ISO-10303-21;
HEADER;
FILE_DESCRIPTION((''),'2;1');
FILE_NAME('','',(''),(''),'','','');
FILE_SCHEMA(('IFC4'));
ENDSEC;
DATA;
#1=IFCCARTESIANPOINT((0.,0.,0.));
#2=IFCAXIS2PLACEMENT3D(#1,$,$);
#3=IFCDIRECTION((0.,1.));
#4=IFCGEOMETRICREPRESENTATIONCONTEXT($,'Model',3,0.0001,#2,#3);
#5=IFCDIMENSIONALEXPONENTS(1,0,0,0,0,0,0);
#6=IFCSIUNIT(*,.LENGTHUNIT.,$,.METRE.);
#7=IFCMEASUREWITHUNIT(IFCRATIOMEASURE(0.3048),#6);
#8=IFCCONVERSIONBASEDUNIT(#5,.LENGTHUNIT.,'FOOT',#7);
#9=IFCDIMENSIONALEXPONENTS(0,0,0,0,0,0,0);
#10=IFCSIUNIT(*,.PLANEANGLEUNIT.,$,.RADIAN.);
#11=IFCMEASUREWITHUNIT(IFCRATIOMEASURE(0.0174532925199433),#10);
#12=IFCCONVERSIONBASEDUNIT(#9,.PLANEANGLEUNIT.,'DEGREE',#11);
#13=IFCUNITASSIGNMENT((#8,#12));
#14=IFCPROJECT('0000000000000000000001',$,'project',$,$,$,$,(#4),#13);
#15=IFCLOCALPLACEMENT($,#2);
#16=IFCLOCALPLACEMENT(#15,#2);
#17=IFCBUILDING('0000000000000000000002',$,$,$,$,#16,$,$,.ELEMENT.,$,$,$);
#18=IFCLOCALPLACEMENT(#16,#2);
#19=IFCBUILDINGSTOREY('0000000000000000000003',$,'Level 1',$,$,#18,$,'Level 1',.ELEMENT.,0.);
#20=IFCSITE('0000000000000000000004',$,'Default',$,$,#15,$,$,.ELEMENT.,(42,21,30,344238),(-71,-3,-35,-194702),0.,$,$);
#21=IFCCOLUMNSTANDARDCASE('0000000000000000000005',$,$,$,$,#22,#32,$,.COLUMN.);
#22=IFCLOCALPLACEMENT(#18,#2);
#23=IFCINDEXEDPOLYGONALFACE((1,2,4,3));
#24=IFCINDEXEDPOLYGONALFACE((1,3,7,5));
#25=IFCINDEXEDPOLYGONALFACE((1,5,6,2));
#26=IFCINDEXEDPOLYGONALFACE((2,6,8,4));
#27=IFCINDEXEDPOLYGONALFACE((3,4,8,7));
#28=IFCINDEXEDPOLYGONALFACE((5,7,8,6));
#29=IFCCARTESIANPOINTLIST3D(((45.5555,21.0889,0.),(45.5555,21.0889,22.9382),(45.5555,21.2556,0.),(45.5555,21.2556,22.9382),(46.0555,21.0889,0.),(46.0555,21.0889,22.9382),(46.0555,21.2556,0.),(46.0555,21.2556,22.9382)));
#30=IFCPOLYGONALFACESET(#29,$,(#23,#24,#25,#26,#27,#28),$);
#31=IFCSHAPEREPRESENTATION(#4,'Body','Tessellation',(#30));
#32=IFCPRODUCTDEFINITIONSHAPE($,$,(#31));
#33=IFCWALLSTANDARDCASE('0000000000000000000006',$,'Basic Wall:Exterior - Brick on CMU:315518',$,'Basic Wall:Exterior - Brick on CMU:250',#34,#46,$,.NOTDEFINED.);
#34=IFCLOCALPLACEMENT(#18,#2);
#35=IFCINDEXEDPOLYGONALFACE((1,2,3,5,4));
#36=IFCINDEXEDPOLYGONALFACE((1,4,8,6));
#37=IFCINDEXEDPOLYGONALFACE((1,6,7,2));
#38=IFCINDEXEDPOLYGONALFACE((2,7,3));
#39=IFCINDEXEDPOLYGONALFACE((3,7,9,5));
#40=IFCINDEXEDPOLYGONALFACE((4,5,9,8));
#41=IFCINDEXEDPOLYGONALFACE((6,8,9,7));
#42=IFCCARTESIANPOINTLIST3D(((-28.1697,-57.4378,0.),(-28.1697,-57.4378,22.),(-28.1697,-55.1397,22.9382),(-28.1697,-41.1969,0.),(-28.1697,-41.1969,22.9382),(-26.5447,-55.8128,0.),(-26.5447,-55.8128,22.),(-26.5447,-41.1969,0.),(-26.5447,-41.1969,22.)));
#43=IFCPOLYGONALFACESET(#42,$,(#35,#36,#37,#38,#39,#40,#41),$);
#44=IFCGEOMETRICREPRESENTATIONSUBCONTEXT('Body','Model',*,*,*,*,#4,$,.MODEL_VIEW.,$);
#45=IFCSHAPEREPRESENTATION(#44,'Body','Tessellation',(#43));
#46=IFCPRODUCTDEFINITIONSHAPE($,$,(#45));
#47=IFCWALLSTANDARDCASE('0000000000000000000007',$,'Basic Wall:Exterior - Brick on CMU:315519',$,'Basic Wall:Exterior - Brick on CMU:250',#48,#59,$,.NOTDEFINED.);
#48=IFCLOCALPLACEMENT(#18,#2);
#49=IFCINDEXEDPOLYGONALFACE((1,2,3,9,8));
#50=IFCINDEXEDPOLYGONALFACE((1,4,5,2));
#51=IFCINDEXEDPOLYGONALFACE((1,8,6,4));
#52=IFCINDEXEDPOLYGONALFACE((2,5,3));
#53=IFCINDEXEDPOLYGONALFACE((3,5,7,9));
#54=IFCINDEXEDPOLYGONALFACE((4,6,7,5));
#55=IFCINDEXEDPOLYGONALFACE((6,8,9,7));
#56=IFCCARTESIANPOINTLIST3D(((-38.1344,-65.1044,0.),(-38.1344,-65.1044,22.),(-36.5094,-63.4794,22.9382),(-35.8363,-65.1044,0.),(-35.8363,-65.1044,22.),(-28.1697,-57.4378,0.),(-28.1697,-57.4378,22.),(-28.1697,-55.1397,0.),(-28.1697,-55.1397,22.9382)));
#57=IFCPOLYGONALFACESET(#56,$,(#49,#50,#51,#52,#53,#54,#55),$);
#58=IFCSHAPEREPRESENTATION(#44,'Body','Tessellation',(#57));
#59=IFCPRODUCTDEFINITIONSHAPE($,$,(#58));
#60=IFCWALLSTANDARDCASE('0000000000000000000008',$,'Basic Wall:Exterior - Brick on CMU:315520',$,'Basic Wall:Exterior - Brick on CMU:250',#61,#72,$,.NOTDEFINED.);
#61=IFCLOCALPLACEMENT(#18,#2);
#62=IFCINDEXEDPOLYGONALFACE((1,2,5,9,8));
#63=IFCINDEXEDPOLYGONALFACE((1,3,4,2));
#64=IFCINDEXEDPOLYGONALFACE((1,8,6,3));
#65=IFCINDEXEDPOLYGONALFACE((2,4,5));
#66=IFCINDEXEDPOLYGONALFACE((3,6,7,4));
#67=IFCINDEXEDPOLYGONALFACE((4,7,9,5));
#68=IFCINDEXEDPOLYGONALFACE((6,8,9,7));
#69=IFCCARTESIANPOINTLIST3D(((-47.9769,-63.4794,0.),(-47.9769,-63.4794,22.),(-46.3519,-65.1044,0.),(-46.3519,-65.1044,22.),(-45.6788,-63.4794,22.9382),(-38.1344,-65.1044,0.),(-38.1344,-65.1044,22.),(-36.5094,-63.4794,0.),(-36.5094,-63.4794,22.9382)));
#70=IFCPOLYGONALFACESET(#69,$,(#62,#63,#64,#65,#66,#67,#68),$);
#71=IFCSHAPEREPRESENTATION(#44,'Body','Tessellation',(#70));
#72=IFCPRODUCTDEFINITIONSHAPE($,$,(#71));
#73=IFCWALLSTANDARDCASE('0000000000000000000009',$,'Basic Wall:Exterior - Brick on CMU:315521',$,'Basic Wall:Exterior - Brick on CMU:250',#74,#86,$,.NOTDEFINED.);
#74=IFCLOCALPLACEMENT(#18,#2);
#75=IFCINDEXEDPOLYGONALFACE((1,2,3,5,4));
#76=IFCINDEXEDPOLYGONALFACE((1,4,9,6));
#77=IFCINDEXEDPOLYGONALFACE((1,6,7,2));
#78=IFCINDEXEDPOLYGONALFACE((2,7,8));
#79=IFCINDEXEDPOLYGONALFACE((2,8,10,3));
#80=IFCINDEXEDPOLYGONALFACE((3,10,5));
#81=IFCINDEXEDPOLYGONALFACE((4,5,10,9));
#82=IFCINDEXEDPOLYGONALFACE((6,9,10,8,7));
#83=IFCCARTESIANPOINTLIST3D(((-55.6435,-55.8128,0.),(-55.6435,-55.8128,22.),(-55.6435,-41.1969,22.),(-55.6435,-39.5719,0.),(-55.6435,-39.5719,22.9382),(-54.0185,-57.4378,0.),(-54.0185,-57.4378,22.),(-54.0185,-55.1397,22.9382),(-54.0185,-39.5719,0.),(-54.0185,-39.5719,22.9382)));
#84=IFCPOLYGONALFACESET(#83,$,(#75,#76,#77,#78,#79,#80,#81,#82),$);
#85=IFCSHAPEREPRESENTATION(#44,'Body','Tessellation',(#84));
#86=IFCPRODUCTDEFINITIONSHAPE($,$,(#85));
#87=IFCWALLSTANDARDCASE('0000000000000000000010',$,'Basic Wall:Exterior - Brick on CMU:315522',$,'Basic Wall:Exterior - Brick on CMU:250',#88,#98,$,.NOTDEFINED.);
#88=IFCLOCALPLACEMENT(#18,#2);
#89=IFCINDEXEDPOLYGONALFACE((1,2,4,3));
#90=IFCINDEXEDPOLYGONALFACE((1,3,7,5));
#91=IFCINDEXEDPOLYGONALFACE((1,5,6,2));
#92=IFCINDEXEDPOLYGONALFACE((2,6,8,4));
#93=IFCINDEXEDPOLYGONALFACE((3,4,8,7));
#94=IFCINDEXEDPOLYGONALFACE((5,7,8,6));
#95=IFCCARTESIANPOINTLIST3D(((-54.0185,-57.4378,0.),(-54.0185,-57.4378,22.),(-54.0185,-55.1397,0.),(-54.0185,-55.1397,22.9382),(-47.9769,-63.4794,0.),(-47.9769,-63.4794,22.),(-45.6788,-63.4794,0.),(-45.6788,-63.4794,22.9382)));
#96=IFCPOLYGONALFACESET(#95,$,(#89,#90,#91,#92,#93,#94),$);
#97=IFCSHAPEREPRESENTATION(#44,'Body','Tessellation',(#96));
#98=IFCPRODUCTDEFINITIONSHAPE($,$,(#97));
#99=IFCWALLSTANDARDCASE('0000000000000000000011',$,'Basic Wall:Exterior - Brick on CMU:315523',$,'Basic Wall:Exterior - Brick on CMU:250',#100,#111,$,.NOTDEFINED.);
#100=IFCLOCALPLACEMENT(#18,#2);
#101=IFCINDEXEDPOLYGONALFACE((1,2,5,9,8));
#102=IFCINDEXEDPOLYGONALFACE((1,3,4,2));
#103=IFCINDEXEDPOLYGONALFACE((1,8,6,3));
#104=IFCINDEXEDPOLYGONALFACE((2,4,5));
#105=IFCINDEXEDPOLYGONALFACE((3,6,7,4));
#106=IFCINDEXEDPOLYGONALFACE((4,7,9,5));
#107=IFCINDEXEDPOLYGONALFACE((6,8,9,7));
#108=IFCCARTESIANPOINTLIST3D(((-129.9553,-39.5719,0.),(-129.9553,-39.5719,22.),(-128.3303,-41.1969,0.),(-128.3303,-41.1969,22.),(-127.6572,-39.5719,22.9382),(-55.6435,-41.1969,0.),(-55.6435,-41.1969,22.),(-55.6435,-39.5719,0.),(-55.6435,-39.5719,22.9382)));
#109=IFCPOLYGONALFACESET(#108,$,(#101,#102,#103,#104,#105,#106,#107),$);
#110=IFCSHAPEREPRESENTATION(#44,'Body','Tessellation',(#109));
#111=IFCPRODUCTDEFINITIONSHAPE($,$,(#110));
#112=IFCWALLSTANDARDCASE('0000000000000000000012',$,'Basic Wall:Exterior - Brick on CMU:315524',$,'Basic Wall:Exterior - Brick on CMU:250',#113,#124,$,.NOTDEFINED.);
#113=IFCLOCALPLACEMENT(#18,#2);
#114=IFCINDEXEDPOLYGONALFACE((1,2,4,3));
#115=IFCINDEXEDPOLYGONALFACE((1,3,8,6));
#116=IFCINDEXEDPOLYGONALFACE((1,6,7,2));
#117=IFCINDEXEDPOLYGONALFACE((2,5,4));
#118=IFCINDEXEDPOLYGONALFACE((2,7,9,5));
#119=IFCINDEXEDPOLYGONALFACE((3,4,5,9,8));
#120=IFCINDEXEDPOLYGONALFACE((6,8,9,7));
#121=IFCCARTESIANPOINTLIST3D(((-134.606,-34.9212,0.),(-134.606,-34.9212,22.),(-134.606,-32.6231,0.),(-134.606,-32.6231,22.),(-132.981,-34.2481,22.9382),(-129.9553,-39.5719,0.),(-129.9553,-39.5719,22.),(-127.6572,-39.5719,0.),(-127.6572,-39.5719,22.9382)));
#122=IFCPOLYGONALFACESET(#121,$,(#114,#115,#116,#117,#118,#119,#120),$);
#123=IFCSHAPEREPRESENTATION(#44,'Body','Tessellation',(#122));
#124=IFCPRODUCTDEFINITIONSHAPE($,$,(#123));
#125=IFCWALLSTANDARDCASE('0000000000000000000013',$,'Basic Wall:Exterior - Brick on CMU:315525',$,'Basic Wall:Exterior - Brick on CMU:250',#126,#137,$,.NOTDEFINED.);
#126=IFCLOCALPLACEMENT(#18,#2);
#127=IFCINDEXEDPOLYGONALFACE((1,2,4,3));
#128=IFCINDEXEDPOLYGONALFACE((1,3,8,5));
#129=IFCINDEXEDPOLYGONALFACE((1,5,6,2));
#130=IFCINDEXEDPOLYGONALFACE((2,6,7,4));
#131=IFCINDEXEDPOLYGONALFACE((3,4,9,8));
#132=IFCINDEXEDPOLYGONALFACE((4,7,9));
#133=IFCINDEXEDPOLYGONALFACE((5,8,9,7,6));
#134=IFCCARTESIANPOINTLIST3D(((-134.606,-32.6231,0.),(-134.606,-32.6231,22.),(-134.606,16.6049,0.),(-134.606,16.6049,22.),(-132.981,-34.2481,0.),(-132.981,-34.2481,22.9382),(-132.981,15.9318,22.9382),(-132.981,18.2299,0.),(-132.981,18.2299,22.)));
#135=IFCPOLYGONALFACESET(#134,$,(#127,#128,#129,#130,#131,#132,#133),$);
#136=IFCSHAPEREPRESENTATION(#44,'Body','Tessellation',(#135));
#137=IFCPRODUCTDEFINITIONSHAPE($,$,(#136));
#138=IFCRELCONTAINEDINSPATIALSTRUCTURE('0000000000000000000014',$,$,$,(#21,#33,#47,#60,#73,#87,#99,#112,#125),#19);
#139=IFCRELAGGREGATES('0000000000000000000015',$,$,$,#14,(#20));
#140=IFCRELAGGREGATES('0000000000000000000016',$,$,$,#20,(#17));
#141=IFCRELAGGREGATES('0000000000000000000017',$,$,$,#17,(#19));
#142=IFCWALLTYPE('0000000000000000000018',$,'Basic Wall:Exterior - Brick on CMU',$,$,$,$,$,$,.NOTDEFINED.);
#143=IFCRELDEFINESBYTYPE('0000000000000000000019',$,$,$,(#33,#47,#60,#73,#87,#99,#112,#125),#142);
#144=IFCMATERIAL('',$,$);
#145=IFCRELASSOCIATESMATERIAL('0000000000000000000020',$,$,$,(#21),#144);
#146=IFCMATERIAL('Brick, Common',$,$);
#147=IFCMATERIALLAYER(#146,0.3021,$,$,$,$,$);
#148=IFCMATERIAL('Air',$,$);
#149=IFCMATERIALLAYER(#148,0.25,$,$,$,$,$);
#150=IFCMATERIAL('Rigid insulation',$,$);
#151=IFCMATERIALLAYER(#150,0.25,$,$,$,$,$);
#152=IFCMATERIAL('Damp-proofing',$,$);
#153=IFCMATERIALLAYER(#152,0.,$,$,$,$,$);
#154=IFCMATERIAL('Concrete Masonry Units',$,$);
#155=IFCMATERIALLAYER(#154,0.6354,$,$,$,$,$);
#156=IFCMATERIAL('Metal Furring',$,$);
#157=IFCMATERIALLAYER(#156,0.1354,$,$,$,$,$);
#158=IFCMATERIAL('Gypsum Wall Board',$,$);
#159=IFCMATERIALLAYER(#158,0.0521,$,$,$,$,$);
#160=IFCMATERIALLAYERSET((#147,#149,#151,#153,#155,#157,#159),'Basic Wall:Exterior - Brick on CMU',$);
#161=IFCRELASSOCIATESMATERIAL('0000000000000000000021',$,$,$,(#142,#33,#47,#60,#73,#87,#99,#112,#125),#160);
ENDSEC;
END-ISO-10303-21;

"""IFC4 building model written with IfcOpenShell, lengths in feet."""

from ifc_helpers import new_model, entity, si_unit, converted_unit, direction, frame, origin, place, context, subcontext, project, spatial, polyline, rectangle, outline, extrude, clip, bounded_halfspace, material, layer, layer_set, layer_usage, type_object, element, save


model = new_model("IFC4")

# Units and contexts
model_context = context("Model", 3, precision=0.0001, world=origin(), true_north=direction((0.0, 1.0)))
body_context = subcontext(model_context, "Body", "Model", "MODEL_VIEW")
ifc_project = project(units=[converted_unit("LENGTHUNIT", "FOOT", entity("IfcRatioMeasure", 0.3048), si_unit("LENGTHUNIT", "METRE"), dimensions=[1, 0, 0, 0, 0, 0, 0]), converted_unit("PLANEANGLEUNIT", "DEGREE", entity("IfcRatioMeasure", 0.0174532925199433), si_unit("PLANEANGLEUNIT", "RADIAN"), dimensions=[0, 0, 0, 0, 0, 0, 0])], contexts=[model_context])

# Site, building, storey
site_placement = place(None, origin())
site = spatial("IfcSite", under=ifc_project, at=site_placement, Name="Default", CompositionType="ELEMENT", RefLatitude=(42, 21, 30, 344238), RefLongitude=(-71, -3, -35, -194702), RefElevation=0.0)
building_placement = place(site_placement, origin())
building = spatial("IfcBuilding", under=site, at=building_placement, CompositionType="ELEMENT")
storey_placement = place(building_placement, origin())
storey = spatial("IfcBuildingStorey", under=building, at=storey_placement, Name="Level 1", LongName="Level 1", CompositionType="ELEMENT", Elevation=0.0)

# Column
ifc_material_1 = material(Name="")
wall_1_placement = place(storey_placement, frame((45.8055, 21.2556, 0.0), z_axis=(0.0, 0.0, 1.0), x_axis=(0.0, -1.0, 0.0)))
for number, where, z_axis, x_axis in (
    (1, (0.0833, 0.0, 0.0), (0.0, 0.0, 1.0), (1.0, 0.0, 0.0)),
):
    element("IfcColumnStandardCase", number, at=place(wall_1_placement, frame(where, z_axis=z_axis, x_axis=x_axis)), inside=storey, material=ifc_material_1, PredefinedType="COLUMN", context=model_context, shape_type="SweptSolid", body=[
        extrude(rectangle(XDim=0.1667, YDim=0.5), origin(), (0.0, 0.0, 1.0), 22.9382),
    ])

# Walls
ifc_material_2 = material(Name="Brick, Common")
ifc_layer_1 = layer(ifc_material_2, 0.3021)
ifc_material_3 = material(Name="Air")
ifc_layer_2 = layer(ifc_material_3, 0.25)
ifc_material_4 = material(Name="Rigid insulation")
ifc_layer_3 = layer(ifc_material_4, 0.25)
ifc_material_5 = material(Name="Damp-proofing")
ifc_layer_4 = layer(ifc_material_5, 0.0)
ifc_material_6 = material(Name="Concrete Masonry Units")
ifc_layer_5 = layer(ifc_material_6, 0.6354)
ifc_material_7 = material(Name="Metal Furring")
ifc_layer_6 = layer(ifc_material_7, 0.1354)
ifc_material_8 = material(Name="Gypsum Wall Board")
ifc_layer_7 = layer(ifc_material_8, 0.0521)
ifc_layer_set = layer_set([ifc_layer_1, ifc_layer_2, ifc_layer_3, ifc_layer_4, ifc_layer_5, ifc_layer_6, ifc_layer_7], Name="Basic Wall:Exterior - Brick on CMU")
ifc_layer_usage_1 = layer_usage(ifc_layer_set, "AXIS2", "NEGATIVE", 0.8125)
wall_type = type_object("IfcWallType", Name="Basic Wall:Exterior - Brick on CMU", PredefinedType="NOTDEFINED", material=ifc_layer_set)
wall_2_placement = place(storey_placement, frame((-27.3572, -41.1969, 0.0), z_axis=(0.0, 0.0, 1.0), x_axis=(0.0, -1.0, 0.0)))
element("IfcWallStandardCase", 2, at=wall_2_placement, inside=storey, type_object=wall_type, material=ifc_layer_usage_1, Name="Basic Wall:Exterior - Brick on CMU:315518", ObjectType="Basic Wall:Exterior - Brick on CMU:250", PredefinedType="NOTDEFINED", context=body_context, shape_type="Clipping", body=[
    clip(clip(extrude(outline(polyline([(16.2409, -0.8125), (14.6159, 0.8125), (0.0, 0.8125), (0.0, -0.8125), (13.9428, -0.8125), (16.2409, -0.8125)])), origin(), (0.0, 0.0, 1.0), 22.9382), bounded_halfspace(frame((13.9428, -0.8125, 22.9382), z_axis=(0.353553, 0.353553, 0.866025), x_axis=(-0.707107, 0.707107, 0.0)), False, frame((13.9428, -0.8125, 22.9382)), polyline([(0.0, 0.0), (2.2981, 0.0), (0.6731, 1.625), (0.0, 0.0)]))), bounded_halfspace(frame((0.0, -0.8125, 22.9382), z_axis=(0.0, 0.5, 0.866025), x_axis=(-1.0, 0.0, 0.0)), False, frame((0.0, -0.8125, 22.9382)), polyline([(0.0, 0.0), (13.9428, 0.0), (14.6159, 1.625), (0.0, 1.625), (0.0, 0.0)]))),
])
ifc_layer_usage_2 = layer_usage(ifc_layer_set, "AXIS2", "NEGATIVE", 0.8125)
wall_3_placement = place(storey_placement, frame((-27.5952, -55.7142, 0.0), z_axis=(0.0, 0.0, 1.0), x_axis=(-0.707107, -0.707107, 0.0)))
element("IfcWallStandardCase", 3, at=wall_3_placement, inside=storey, type_object=wall_type, material=ifc_layer_usage_2, Name="Basic Wall:Exterior - Brick on CMU:315519", ObjectType="Basic Wall:Exterior - Brick on CMU:250", PredefinedType="NOTDEFINED", context=body_context, shape_type="Clipping", body=[
    clip(clip(extrude(outline(polyline([(14.0922, -0.8125), (12.4672, 0.8125), (1.625, 0.8125), (0.0, -0.8125), (11.7941, -0.8125), (14.0922, -0.8125)])), origin(), (0.0, 0.0, 1.0), 22.9382), bounded_halfspace(frame((0.0, -0.8125, 22.9382), z_axis=(0.0, 0.5, 0.866025), x_axis=(-1.0, 0.0, 0.0)), False, frame((0.0, -0.8125, 22.9382)), polyline([(0.0, 0.0), (11.7941, 0.0), (12.4672, 1.625), (1.625, 1.625), (0.0, 0.0)]))), bounded_halfspace(frame((11.7941, -0.8125, 22.9382), z_axis=(0.353553, 0.353553, 0.866025), x_axis=(-0.707107, 0.707107, 0.0)), False, frame((11.7941, -0.8125, 22.9382)), polyline([(0.0, 0.0), (2.2981, 0.0), (0.6731, 1.625), (0.0, 0.0)]))),
])
ifc_layer_usage_3 = layer_usage(ifc_layer_set, "AXIS2", "NEGATIVE", 0.8125)
wall_4_placement = place(storey_placement, frame((-36.5094, -64.2919, 0.0), z_axis=(0.0, 0.0, 1.0), x_axis=(-1.0, 0.0, 0.0)))
element("IfcWallStandardCase", 4, at=wall_4_placement, inside=storey, type_object=wall_type, material=ifc_layer_usage_3, Name="Basic Wall:Exterior - Brick on CMU:315520", ObjectType="Basic Wall:Exterior - Brick on CMU:250", PredefinedType="NOTDEFINED", context=body_context, shape_type="Clipping", body=[
    clip(clip(extrude(outline(polyline([(11.4675, -0.8125), (9.8425, 0.8125), (1.625, 0.8125), (0.0, -0.8125), (9.1694, -0.8125), (11.4675, -0.8125)])), origin(), (0.0, 0.0, 1.0), 22.9382), bounded_halfspace(frame((9.1694, -0.8125, 22.9382), z_axis=(0.353553, 0.353553, 0.866025), x_axis=(-0.707107, 0.707107, 0.0)), False, frame((9.1694, -0.8125, 22.9382)), polyline([(0.0, 0.0), (2.2981, 0.0), (0.6731, 1.625), (0.0, 0.0)]))), bounded_halfspace(frame((0.0, -0.8125, 22.9382), z_axis=(0.0, 0.5, 0.866025), x_axis=(-1.0, 0.0, 0.0)), False, frame((0.0, -0.8125, 22.9382)), polyline([(0.0, 0.0), (9.1694, 0.0), (9.8425, 1.625), (1.625, 1.625), (0.0, 0.0)]))),
])
ifc_layer_usage_4 = layer_usage(ifc_layer_set, "AXIS2", "POSITIVE", -0.8125)
wall_5_placement = place(storey_placement, frame((-54.831, -39.5719, 0.0), z_axis=(0.0, 0.0, 1.0), x_axis=(0.0, -1.0, 0.0)))
element("IfcWallStandardCase", 5, at=wall_5_placement, inside=storey, type_object=wall_type, material=ifc_layer_usage_4, Name="Basic Wall:Exterior - Brick on CMU:315521", ObjectType="Basic Wall:Exterior - Brick on CMU:250", PredefinedType="NOTDEFINED", context=body_context, shape_type="Clipping", body=[
    clip(clip(clip(extrude(outline(polyline([(16.2409, -0.8125), (17.8659, 0.8125), (15.5678, 0.8125), (0.0, 0.8125), (0.0, -0.8125), (1.625, -0.8125), (16.2409, -0.8125)])), origin(), (0.0, 0.0, 1.0), 22.9382), bounded_halfspace(frame((1.625, -0.8125, 22.0), z_axis=(0.0, -0.5, 0.866025), x_axis=(1.0, 0.0, 0.0)), False, frame((1.625, -0.8125, 22.0)), polyline([(0.0, 0.0), (14.6159, 0.0), (13.9428, 1.625), (-1.625, 1.625), (0.0, 0.0)]))), bounded_halfspace(frame((16.2409, -0.8125, 22.0), z_axis=(0.353553, -0.353553, 0.866025), x_axis=(0.707107, 0.707107, 0.0)), False, frame((16.2409, -0.8125, 22.0)), polyline([(0.0, 0.0), (1.625, 1.625), (-0.6731, 1.625), (0.0, 0.0)]))), bounded_halfspace(frame((0.0, -0.8125, 22.9382), z_axis=(0.5, 0.0, 0.866025), x_axis=(0.0, 1.0, 0.0)), False, frame((0.0, -0.8125, 22.9382)), polyline([(0.0, 0.0), (1.625, 0.0), (0.0, 1.625), (0.0, 0.0)]))),
])
ifc_layer_usage_5 = layer_usage(ifc_layer_set, "AXIS2", "POSITIVE", -0.8125)
wall_6_placement = place(storey_placement, frame((-54.593, -55.7142, 0.0), z_axis=(0.0, 0.0, 1.0), x_axis=(0.707107, -0.707107, 0.0)))
element("IfcWallStandardCase", 6, at=wall_6_placement, inside=storey, type_object=wall_type, material=ifc_layer_usage_5, Name="Basic Wall:Exterior - Brick on CMU:315522", ObjectType="Basic Wall:Exterior - Brick on CMU:250", PredefinedType="NOTDEFINED", context=body_context, shape_type="Clipping", body=[
    clip(extrude(outline(polyline([(10.1691, -0.8125), (11.7941, 0.8125), (0.0, 0.8125), (1.625, -0.8125), (10.1691, -0.8125)])), origin(), (0.0, 0.0, 1.0), 22.9382), bounded_halfspace(frame((1.625, -0.8125, 22.0), z_axis=(0.0, -0.5, 0.866025), x_axis=(1.0, 0.0, 0.0)), False, frame((1.625, -0.8125, 22.0)), polyline([(0.0, 0.0), (8.5441, 0.0), (10.1691, 1.625), (-1.625, 1.625), (0.0, 0.0)]))),
])
ifc_layer_usage_6 = layer_usage(ifc_layer_set, "AXIS2", "POSITIVE", -0.8125)
wall_7_placement = place(storey_placement, frame((-129.9553, -40.3844, 0.0)))
element("IfcWallStandardCase", 7, at=wall_7_placement, inside=storey, type_object=wall_type, material=ifc_layer_usage_6, Name="Basic Wall:Exterior - Brick on CMU:315523", ObjectType="Basic Wall:Exterior - Brick on CMU:250", PredefinedType="NOTDEFINED", context=body_context, shape_type="Clipping", body=[
    clip(clip(extrude(outline(polyline([(74.3118, -0.8125), (74.3118, 0.8125), (2.2981, 0.8125), (0.0, 0.8125), (1.625, -0.8125), (74.3118, -0.8125)])), origin(), (0.0, 0.0, 1.0), 22.9382), bounded_halfspace(frame((2.2981, 0.8125, 22.9382), z_axis=(-0.353553, -0.353553, 0.866025), x_axis=(0.707107, -0.707107, 0.0)), False, frame((2.2981, 0.8125, 22.9382)), polyline([(0.0, 0.0), (-2.2981, 0.0), (-0.6731, -1.625), (0.0, 0.0)]))), bounded_halfspace(frame((1.625, -0.8125, 22.0), z_axis=(0.0, -0.5, 0.866025), x_axis=(1.0, 0.0, 0.0)), False, frame((1.625, -0.8125, 22.0)), polyline([(0.0, 0.0), (72.6868, 0.0), (72.6868, 1.625), (0.6731, 1.625), (0.0, 0.0)]))),
])
ifc_layer_usage_7 = layer_usage(ifc_layer_set, "AXIS2", "NEGATIVE", 0.8125)
wall_8_placement = place(storey_placement, frame((-128.2317, -40.1464, 0.0), z_axis=(0.0, 0.0, 1.0), x_axis=(-0.707107, 0.707107, 0.0)))
element("IfcWallStandardCase", 8, at=wall_8_placement, inside=storey, type_object=wall_type, material=ifc_layer_usage_7, Name="Basic Wall:Exterior - Brick on CMU:315524", ObjectType="Basic Wall:Exterior - Brick on CMU:250", PredefinedType="NOTDEFINED", context=body_context, shape_type="Clipping", body=[
    clip(clip(extrude(outline(polyline([(9.8271, -0.8125), (8.2021, 0.8125), (1.625, 0.8125), (0.0, -0.8125), (7.529, -0.8125), (9.8271, -0.8125)])), origin(), (0.0, 0.0, 1.0), 22.9382), bounded_halfspace(frame((0.0, -0.8125, 22.9382), z_axis=(0.0, 0.5, 0.866025), x_axis=(-1.0, 0.0, 0.0)), False, frame((0.0, -0.8125, 22.9382)), polyline([(0.0, 0.0), (7.529, 0.0), (8.2021, 1.625), (1.625, 1.625), (0.0, 0.0)]))), bounded_halfspace(frame((7.529, -0.8125, 22.9382), z_axis=(0.353553, 0.353553, 0.866025), x_axis=(-0.707107, 0.707107, 0.0)), False, frame((7.529, -0.8125, 22.9382)), polyline([(0.0, 0.0), (2.2981, 0.0), (0.6731, 1.625), (0.0, 0.0)]))),
])
ifc_layer_usage_8 = layer_usage(ifc_layer_set, "AXIS2", "NEGATIVE", 0.8125)
wall_9_placement = place(storey_placement, frame((-133.7935, -34.2481, 0.0), z_axis=(0.0, 0.0, 1.0), x_axis=(0.0, 1.0, 0.0)))
element("IfcWallStandardCase", 9, at=wall_9_placement, inside=storey, type_object=wall_type, material=ifc_layer_usage_8, Name="Basic Wall:Exterior - Brick on CMU:315525", ObjectType="Basic Wall:Exterior - Brick on CMU:250", PredefinedType="NOTDEFINED", context=body_context, shape_type="Clipping", body=[
    clip(clip(extrude(outline(polyline([(52.478, -0.8125), (50.853, 0.8125), (1.625, 0.8125), (0.0, -0.8125), (50.1799, -0.8125), (52.478, -0.8125)])), origin(), (0.0, 0.0, 1.0), 22.9382), bounded_halfspace(frame((0.0, -0.8125, 22.9382), z_axis=(0.0, 0.5, 0.866025), x_axis=(-1.0, 0.0, 0.0)), False, frame((0.0, -0.8125, 22.9382)), polyline([(0.0, 0.0), (50.1799, 0.0), (50.853, 1.625), (1.625, 1.625), (0.0, 0.0)]))), bounded_halfspace(frame((50.1799, -0.8125, 22.9382), z_axis=(0.353553, 0.353553, 0.866025), x_axis=(-0.707107, 0.707107, 0.0)), False, frame((50.1799, -0.8125, 22.9382)), polyline([(0.0, 0.0), (2.2981, 0.0), (0.6731, 1.625), (0.0, 0.0)]))),
])

save(model, "model.ifc")
